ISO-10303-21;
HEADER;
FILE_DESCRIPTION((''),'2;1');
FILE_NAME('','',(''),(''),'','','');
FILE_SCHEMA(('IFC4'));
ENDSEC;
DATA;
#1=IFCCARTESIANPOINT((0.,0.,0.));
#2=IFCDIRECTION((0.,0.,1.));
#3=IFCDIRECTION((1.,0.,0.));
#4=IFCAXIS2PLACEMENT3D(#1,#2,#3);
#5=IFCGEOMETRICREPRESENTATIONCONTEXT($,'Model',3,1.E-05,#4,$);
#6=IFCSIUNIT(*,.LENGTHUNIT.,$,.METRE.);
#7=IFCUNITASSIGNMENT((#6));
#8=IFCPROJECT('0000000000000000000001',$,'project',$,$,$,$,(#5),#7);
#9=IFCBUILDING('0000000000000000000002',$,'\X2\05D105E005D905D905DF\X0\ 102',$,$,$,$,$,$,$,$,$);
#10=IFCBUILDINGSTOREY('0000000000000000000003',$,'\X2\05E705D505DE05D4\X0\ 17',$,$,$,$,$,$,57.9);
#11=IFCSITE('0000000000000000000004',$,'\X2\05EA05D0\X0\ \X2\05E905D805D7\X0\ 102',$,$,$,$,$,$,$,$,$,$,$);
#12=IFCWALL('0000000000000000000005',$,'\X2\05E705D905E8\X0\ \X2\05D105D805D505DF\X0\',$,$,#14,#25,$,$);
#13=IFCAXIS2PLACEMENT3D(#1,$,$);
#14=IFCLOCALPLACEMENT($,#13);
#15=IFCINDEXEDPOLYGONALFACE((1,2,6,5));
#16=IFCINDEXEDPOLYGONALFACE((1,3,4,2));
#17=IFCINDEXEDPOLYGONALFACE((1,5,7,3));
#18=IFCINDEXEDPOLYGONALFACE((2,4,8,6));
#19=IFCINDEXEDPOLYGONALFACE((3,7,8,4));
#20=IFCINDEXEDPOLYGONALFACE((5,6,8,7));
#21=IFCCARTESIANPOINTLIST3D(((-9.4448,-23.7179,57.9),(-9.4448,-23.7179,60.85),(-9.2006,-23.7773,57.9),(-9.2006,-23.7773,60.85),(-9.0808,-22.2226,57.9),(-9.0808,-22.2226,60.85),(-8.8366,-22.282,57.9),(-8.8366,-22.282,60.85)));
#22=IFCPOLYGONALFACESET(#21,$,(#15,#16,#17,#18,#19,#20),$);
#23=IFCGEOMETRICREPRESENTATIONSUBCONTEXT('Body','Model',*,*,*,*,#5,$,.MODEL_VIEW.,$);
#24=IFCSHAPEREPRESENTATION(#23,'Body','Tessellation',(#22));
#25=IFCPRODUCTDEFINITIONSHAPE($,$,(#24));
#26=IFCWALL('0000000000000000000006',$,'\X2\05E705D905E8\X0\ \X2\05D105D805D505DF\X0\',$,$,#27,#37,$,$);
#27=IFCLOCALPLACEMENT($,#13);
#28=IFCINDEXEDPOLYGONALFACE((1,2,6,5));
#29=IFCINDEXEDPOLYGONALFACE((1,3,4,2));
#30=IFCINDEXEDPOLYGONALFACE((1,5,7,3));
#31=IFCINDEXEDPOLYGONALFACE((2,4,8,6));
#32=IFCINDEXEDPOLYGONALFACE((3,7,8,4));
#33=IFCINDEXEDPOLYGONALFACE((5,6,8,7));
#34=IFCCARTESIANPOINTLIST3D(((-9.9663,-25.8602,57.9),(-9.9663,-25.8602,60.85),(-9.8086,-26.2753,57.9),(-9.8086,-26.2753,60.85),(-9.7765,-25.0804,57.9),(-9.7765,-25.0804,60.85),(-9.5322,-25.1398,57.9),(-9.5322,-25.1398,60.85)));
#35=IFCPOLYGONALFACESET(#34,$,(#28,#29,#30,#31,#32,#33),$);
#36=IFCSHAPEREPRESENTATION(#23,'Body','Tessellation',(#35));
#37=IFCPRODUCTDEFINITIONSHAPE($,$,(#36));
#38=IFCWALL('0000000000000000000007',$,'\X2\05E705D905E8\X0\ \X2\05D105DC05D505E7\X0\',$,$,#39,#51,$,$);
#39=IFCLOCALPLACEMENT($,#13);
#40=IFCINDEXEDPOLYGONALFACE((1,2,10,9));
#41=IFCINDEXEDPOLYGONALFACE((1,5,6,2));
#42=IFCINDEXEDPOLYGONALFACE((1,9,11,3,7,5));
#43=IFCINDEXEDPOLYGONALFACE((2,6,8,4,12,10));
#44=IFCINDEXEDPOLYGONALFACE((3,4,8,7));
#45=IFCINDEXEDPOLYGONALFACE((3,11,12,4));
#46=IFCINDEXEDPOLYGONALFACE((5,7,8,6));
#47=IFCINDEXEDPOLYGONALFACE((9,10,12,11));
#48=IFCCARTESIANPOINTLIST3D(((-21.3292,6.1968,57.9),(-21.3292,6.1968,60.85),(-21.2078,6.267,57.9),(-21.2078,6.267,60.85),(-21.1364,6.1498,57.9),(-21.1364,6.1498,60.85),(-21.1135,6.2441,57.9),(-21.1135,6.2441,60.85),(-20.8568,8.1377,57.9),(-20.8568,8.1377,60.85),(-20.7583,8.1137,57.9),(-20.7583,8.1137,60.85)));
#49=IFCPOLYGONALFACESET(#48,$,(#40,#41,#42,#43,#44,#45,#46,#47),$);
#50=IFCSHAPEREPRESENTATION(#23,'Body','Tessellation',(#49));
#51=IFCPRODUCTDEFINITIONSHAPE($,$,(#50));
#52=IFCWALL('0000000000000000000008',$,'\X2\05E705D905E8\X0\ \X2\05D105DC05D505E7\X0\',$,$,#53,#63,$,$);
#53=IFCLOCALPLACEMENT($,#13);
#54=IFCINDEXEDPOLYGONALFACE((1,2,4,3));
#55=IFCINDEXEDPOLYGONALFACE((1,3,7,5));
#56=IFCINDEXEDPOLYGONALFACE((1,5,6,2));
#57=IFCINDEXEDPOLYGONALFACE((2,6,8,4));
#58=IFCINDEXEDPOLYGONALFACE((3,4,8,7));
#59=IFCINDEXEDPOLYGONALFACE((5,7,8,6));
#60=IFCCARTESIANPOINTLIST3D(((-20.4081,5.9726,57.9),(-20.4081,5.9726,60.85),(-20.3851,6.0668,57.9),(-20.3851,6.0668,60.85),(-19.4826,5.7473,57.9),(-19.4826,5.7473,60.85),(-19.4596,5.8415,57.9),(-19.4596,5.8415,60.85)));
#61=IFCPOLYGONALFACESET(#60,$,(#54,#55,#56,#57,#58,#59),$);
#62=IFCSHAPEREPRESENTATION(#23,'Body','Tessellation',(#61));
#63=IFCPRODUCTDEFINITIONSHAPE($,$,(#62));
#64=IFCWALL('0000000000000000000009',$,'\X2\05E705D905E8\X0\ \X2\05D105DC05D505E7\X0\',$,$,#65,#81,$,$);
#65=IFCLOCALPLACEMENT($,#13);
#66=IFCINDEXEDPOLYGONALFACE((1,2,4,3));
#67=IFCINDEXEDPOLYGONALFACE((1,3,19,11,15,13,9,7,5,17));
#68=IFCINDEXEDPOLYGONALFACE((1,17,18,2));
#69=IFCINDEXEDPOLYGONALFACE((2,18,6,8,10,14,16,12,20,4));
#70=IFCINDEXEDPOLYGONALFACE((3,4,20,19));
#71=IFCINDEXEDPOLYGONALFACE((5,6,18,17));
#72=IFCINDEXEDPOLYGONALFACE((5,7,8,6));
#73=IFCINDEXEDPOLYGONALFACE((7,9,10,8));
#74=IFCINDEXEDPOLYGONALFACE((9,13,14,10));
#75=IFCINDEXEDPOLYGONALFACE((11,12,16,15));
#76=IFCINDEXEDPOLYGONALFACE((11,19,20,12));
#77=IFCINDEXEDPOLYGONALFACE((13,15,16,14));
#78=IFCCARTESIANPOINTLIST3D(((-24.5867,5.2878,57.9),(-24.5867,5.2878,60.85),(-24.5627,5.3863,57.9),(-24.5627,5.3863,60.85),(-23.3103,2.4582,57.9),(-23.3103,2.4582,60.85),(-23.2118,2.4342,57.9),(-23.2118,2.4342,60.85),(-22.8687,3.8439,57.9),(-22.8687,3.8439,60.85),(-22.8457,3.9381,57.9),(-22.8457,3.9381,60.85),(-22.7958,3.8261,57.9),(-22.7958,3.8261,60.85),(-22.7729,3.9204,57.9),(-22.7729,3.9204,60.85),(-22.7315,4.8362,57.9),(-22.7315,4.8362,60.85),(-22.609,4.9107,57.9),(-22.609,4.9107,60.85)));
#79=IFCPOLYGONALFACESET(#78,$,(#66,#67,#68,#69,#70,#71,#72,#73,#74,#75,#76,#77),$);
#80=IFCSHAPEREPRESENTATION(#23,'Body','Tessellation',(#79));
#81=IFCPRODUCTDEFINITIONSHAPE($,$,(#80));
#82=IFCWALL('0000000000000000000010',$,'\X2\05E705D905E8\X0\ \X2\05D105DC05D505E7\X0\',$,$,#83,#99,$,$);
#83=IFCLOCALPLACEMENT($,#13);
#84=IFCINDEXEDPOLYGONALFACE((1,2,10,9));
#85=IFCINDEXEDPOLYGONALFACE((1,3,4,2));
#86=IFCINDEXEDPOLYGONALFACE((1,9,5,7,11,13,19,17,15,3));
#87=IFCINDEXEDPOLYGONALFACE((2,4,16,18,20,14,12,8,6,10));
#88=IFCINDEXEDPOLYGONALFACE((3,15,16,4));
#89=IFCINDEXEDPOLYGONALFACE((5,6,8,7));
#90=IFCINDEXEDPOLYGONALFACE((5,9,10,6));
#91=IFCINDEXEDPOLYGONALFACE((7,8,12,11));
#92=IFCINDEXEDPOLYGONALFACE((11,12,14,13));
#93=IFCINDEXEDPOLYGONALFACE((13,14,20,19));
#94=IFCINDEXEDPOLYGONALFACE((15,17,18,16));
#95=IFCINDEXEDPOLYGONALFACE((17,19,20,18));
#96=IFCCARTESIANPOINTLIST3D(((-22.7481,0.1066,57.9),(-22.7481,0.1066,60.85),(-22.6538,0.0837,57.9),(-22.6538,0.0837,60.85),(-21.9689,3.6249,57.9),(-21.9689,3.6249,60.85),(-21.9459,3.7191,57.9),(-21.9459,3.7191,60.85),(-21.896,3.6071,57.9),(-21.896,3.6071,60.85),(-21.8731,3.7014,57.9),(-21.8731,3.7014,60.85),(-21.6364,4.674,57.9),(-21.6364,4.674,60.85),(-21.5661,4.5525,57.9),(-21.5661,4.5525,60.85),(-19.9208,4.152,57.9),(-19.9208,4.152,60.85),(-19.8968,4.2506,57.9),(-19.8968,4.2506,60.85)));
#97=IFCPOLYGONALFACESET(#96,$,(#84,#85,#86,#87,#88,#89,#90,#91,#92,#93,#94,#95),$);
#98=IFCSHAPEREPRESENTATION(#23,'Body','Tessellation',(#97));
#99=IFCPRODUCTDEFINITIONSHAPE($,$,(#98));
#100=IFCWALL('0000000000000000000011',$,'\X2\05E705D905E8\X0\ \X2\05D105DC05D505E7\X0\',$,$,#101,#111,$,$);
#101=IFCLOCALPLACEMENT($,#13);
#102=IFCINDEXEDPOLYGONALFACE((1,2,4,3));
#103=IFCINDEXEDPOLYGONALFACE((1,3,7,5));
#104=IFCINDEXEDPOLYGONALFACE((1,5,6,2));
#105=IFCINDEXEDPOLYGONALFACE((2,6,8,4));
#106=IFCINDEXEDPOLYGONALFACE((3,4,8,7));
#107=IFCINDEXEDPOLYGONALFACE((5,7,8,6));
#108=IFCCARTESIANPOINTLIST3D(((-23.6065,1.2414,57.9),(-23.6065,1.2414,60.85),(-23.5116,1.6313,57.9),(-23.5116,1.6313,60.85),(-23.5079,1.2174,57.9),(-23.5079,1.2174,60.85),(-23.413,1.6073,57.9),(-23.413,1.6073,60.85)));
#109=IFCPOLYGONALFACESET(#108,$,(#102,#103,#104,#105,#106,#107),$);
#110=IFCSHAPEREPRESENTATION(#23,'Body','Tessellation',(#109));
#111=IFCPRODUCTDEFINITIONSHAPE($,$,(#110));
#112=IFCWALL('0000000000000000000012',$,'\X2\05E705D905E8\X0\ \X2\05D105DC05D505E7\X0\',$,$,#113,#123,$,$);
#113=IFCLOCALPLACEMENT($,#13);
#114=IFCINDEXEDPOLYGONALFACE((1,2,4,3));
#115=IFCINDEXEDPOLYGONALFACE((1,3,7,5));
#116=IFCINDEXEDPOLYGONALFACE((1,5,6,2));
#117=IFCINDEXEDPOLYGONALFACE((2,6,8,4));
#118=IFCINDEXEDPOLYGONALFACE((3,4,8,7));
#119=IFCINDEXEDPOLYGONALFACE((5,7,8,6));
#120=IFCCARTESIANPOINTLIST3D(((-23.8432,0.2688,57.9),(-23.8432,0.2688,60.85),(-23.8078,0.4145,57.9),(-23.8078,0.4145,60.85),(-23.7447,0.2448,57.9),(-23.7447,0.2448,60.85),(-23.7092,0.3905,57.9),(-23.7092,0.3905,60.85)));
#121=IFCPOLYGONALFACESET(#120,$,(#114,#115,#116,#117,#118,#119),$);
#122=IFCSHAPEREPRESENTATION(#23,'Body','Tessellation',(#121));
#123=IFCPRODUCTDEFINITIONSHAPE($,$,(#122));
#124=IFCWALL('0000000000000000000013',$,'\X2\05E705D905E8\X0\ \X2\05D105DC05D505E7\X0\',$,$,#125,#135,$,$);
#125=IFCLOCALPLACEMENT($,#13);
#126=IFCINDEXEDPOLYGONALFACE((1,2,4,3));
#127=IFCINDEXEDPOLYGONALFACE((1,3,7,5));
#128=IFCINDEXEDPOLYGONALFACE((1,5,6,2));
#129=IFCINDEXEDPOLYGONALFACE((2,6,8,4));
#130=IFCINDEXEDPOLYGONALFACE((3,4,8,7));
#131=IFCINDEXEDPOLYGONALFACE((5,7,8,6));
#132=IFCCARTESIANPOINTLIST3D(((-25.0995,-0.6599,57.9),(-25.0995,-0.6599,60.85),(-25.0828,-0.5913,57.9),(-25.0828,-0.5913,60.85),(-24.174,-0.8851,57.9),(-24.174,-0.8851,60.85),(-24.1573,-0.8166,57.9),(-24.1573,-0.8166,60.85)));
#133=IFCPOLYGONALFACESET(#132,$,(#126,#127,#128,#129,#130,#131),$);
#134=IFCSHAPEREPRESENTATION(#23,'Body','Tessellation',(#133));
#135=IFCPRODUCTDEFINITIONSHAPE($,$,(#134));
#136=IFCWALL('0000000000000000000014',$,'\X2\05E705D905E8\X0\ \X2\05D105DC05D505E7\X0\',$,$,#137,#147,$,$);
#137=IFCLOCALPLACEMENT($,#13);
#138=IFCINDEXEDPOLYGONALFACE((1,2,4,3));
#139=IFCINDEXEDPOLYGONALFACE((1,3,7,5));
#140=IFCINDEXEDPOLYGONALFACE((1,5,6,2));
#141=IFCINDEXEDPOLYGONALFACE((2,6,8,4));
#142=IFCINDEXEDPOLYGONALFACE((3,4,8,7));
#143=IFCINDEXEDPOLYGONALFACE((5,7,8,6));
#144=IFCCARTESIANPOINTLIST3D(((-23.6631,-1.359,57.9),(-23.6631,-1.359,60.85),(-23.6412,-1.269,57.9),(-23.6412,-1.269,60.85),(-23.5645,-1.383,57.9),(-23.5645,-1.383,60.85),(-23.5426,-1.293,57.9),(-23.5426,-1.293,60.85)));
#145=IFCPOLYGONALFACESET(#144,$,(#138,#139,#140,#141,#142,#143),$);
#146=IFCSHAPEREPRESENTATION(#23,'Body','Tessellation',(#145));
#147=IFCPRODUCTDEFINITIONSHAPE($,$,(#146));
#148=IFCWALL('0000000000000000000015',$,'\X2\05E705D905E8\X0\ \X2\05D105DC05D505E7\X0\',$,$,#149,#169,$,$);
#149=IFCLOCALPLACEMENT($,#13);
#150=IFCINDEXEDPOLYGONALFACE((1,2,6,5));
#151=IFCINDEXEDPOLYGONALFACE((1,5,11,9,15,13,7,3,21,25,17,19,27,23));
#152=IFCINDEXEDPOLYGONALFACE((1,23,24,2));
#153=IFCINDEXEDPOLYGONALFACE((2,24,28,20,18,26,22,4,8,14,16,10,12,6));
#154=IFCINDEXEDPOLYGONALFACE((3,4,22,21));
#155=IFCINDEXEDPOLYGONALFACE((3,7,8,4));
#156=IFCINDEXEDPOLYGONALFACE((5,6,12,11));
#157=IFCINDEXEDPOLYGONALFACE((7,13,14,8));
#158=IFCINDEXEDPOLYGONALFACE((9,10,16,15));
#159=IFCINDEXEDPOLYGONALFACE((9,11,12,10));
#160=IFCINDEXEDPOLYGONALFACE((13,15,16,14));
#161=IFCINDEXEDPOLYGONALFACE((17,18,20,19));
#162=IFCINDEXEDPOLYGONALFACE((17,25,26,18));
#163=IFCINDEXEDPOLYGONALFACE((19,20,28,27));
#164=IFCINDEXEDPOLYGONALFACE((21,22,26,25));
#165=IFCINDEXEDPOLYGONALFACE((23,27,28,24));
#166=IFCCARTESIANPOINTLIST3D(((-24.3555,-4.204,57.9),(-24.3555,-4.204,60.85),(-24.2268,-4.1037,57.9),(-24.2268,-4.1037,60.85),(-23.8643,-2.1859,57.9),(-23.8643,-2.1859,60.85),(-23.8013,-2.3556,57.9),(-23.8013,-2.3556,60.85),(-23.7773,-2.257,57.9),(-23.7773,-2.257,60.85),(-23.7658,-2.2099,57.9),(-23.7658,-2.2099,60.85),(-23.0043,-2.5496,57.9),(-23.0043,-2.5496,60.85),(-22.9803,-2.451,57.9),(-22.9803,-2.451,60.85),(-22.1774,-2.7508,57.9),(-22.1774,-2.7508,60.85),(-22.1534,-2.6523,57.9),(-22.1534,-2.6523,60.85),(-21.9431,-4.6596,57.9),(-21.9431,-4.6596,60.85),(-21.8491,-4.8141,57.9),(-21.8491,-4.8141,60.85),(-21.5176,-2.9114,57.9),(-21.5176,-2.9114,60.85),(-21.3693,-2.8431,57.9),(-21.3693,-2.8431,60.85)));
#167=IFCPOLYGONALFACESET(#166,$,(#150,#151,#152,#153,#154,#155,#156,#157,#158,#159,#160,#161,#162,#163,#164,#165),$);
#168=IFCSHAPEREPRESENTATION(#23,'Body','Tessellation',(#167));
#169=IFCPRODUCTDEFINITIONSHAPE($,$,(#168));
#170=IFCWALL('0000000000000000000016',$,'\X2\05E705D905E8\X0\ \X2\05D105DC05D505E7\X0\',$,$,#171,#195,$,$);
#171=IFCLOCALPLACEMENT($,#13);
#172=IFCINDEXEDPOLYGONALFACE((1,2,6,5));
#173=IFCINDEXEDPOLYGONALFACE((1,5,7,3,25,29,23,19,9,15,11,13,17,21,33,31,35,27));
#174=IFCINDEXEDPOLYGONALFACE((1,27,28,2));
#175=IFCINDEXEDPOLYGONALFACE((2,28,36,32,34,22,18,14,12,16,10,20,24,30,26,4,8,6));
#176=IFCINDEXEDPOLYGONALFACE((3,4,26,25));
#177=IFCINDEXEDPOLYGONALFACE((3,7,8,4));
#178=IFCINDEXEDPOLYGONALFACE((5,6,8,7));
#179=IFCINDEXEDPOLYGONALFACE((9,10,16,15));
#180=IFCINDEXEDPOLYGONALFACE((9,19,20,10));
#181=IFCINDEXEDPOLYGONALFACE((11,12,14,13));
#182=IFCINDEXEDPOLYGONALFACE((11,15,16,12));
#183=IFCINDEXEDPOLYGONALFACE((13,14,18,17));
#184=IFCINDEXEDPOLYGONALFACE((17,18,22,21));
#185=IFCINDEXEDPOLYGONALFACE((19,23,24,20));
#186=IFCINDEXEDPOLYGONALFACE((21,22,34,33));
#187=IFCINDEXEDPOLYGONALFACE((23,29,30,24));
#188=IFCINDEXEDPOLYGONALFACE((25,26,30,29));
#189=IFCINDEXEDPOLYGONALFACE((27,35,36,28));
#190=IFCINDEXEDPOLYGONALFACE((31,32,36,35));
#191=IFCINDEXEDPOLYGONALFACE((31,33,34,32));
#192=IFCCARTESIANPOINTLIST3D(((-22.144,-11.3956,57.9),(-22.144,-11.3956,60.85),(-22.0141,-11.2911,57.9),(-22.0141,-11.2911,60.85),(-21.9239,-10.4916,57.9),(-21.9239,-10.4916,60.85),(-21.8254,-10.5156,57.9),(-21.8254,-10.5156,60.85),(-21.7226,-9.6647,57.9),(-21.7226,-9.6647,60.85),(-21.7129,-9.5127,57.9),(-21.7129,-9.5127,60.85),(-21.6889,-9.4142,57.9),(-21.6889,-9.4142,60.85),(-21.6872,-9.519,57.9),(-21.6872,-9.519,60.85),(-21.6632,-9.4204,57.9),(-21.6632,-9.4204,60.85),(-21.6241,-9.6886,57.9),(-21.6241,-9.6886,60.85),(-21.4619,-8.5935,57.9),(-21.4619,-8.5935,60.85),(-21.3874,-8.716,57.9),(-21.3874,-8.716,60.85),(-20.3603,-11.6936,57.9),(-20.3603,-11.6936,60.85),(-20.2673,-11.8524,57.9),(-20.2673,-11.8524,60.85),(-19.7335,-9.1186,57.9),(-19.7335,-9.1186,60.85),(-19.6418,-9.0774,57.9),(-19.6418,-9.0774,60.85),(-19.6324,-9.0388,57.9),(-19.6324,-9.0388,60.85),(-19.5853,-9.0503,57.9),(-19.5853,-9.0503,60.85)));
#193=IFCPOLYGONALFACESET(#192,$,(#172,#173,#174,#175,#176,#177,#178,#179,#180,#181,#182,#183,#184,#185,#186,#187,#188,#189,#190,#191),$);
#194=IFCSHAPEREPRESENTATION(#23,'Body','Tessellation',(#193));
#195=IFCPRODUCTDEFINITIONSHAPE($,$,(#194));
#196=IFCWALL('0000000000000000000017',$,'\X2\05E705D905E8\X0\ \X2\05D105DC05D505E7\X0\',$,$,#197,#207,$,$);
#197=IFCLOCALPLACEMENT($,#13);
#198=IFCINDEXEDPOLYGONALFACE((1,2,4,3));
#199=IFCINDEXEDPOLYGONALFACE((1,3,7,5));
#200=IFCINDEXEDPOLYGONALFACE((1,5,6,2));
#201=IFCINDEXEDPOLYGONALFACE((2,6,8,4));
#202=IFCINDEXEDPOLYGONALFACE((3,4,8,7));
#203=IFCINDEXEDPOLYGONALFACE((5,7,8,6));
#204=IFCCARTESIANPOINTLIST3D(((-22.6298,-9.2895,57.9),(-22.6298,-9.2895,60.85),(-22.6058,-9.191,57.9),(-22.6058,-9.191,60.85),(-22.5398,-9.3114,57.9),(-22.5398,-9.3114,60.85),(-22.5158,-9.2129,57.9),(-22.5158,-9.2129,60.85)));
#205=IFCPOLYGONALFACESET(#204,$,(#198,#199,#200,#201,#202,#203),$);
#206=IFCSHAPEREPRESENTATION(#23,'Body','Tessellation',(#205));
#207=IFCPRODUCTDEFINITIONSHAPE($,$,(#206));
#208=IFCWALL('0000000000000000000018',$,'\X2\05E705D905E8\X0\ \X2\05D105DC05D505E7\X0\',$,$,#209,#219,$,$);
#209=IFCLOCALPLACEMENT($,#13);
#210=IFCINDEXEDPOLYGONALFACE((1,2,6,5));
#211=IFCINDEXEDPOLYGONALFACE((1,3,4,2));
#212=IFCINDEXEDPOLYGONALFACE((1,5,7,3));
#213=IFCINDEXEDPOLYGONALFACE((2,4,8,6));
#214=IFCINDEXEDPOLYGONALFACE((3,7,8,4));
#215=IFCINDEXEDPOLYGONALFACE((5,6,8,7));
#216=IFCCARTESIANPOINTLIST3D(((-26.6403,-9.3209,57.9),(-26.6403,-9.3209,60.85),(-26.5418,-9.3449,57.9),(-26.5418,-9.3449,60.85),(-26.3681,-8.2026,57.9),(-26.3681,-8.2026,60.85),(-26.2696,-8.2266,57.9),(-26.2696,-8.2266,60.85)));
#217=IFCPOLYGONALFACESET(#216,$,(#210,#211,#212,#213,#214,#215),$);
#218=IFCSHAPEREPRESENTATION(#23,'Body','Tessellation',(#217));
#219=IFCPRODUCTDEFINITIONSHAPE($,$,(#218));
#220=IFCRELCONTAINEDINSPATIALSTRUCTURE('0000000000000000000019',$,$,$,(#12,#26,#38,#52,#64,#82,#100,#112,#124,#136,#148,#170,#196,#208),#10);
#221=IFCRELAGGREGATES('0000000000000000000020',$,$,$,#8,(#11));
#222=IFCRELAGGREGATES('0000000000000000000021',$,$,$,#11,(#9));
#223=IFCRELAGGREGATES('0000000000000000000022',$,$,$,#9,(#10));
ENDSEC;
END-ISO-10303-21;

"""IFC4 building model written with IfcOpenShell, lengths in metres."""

from ifc_helpers import new_model, si_unit, frame, origin_with_axes, context, subcontext, project, spatial, polyline, outline, extrude, element, save


model = new_model("IFC4")

# Units and contexts
model_context = context("Model", 3, precision=1e-05, world=origin_with_axes())
body_context = subcontext(model_context, "Body", "Model", "MODEL_VIEW")
ifc_project = project(units=[si_unit("LENGTHUNIT", "METRE")], contexts=[model_context])

# Site, building, storey
site = spatial("IfcSite", under=ifc_project, Name="תא שטח 102")
building = spatial("IfcBuilding", under=site, Name="בניין 102")
storey = spatial("IfcBuildingStorey", under=building, Name="קומה 17", Elevation=57.9)

# Walls
element("IfcWall", 1, inside=storey, Name="קיר בטון", context=body_context, shape_type="SweptSolid", body=[
    extrude(outline(polyline([(-9.4448, -23.7179), (-9.2006, -23.7773), (-8.8366, -22.282), (-9.0808, -22.2226), (-9.4448, -23.7179)])), frame((0.0, 0.0, 57.9)), (0.0, 0.0, 1.0), 2.95),
])
element("IfcWall", 2, inside=storey, Name="קיר בטון", context=body_context, shape_type="SweptSolid", body=[
    extrude(outline(polyline([(-9.9663, -25.8602), (-9.8086, -26.2753), (-9.5322, -25.1398), (-9.7765, -25.0804), (-9.9663, -25.8602)])), frame((0.0, 0.0, 57.9)), (0.0, 0.0, 1.0), 2.95),
])
element("IfcWall", 3, inside=storey, Name="קיר בלוק", context=body_context, shape_type="SweptSolid", body=[
    extrude(outline(polyline([(-21.1135, 6.2441), (-21.2078, 6.267), (-20.7583, 8.1137), (-20.8568, 8.1377), (-21.3292, 6.1968), (-21.1364, 6.1498), (-21.1135, 6.2441)])), frame((0.0, 0.0, 57.9)), (0.0, 0.0, 1.0), 2.95),
])
element("IfcWall", 4, inside=storey, Name="קיר בלוק", context=body_context, shape_type="SweptSolid", body=[
    extrude(outline(polyline([(-19.4596, 5.8415), (-20.3851, 6.0668), (-20.4081, 5.9726), (-19.4826, 5.7473), (-19.4596, 5.8415)])), frame((0.0, 0.0, 57.9)), (0.0, 0.0, 1.0), 2.95),
])
element("IfcWall", 5, inside=storey, Name="קיר בלוק", context=body_context, shape_type="SweptSolid", body=[
    extrude(outline(polyline([(-23.3103, 2.4582), (-23.2118, 2.4342), (-22.8687, 3.8439), (-22.7958, 3.8261), (-22.7729, 3.9204), (-22.8457, 3.9381), (-22.609, 4.9107), (-24.5627, 5.3863), (-24.5867, 5.2878), (-22.7315, 4.8362), (-23.3103, 2.4582)])), frame((0.0, 0.0, 57.9)), (0.0, 0.0, 1.0), 2.95),
])
element("IfcWall", 6, inside=storey, Name="קיר בלוק", context=body_context, shape_type="SweptSolid", body=[
    extrude(outline(polyline([(-21.9689, 3.6249), (-21.896, 3.6071), (-22.7481, 0.1066), (-22.6538, 0.0837), (-21.5661, 4.5525), (-19.9208, 4.152), (-19.8968, 4.2506), (-21.6364, 4.674), (-21.8731, 3.7014), (-21.9459, 3.7191), (-21.9689, 3.6249)])), frame((0.0, 0.0, 57.9)), (0.0, 0.0, 1.0), 2.95),
])
element("IfcWall", 7, inside=storey, Name="קיר בלוק", context=body_context, shape_type="SweptSolid", body=[
    extrude(outline(polyline([(-23.413, 1.6073), (-23.5116, 1.6313), (-23.6065, 1.2414), (-23.5079, 1.2174), (-23.413, 1.6073)])), frame((0.0, 0.0, 57.9)), (0.0, 0.0, 1.0), 2.95),
])
element("IfcWall", 8, inside=storey, Name="קיר בלוק", context=body_context, shape_type="SweptSolid", body=[
    extrude(outline(polyline([(-23.8078, 0.4145), (-23.8432, 0.2688), (-23.7447, 0.2448), (-23.7092, 0.3905), (-23.8078, 0.4145)])), frame((0.0, 0.0, 57.9)), (0.0, 0.0, 1.0), 2.95),
])
element("IfcWall", 9, inside=storey, Name="קיר בלוק", context=body_context, shape_type="SweptSolid", body=[
    extrude(outline(polyline([(-25.0828, -0.5913), (-25.0995, -0.6599), (-24.174, -0.8851), (-24.1573, -0.8166), (-25.0828, -0.5913)])), frame((0.0, 0.0, 57.9)), (0.0, 0.0, 1.0), 2.95),
])
element("IfcWall", 10, inside=storey, Name="קיר בלוק", context=body_context, shape_type="SweptSolid", body=[
    extrude(outline(polyline([(-23.5426, -1.293), (-23.6412, -1.269), (-23.6631, -1.359), (-23.5645, -1.383), (-23.5426, -1.293)])), frame((0.0, 0.0, 57.9)), (0.0, 0.0, 1.0), 2.95),
])
element("IfcWall", 11, inside=storey, Name="קיר בלוק", context=body_context, shape_type="SweptSolid", body=[
    extrude(outline(polyline([(-24.2268, -4.1037), (-23.8013, -2.3556), (-23.0043, -2.5496), (-22.9803, -2.451), (-23.7773, -2.257), (-23.7658, -2.2099), (-23.8643, -2.1859), (-24.3555, -4.204), (-21.8491, -4.8141), (-21.3693, -2.8431), (-22.1534, -2.6523), (-22.1774, -2.7508), (-21.5176, -2.9114), (-21.9431, -4.6596), (-24.2268, -4.1037)])), frame((0.0, 0.0, 57.9)), (0.0, 0.0, 1.0), 2.95),
])
element("IfcWall", 12, inside=storey, Name="קיר בלוק", context=body_context, shape_type="SweptSolid", body=[
    extrude(outline(polyline([(-21.7129, -9.5127), (-21.6872, -9.519), (-21.7226, -9.6647), (-21.6241, -9.6886), (-21.3874, -8.716), (-19.7335, -9.1186), (-20.3603, -11.6936), (-22.0141, -11.2911), (-21.8254, -10.5156), (-21.9239, -10.4916), (-22.144, -11.3956), (-20.2673, -11.8524), (-19.5853, -9.0503), (-19.6418, -9.0774), (-19.6324, -9.0388), (-21.4619, -8.5935), (-21.6632, -9.4204), (-21.6889, -9.4142), (-21.7129, -9.5127)])), frame((0.0, 0.0, 57.9)), (0.0, 0.0, 1.0), 2.95),
])
element("IfcWall", 13, inside=storey, Name="קיר בלוק", context=body_context, shape_type="SweptSolid", body=[
    extrude(outline(polyline([(-22.6058, -9.191), (-22.6298, -9.2895), (-22.5398, -9.3114), (-22.5158, -9.2129), (-22.6058, -9.191)])), frame((0.0, 0.0, 57.9)), (0.0, 0.0, 1.0), 2.95),
])
element("IfcWall", 14, inside=storey, Name="קיר בלוק", context=body_context, shape_type="SweptSolid", body=[
    extrude(outline(polyline([(-26.6403, -9.3209), (-26.5418, -9.3449), (-26.2696, -8.2266), (-26.3681, -8.2026), (-26.6403, -9.3209)])), frame((0.0, 0.0, 57.9)), (0.0, 0.0, 1.0), 2.95),
])

save(model, "model.ifc")
